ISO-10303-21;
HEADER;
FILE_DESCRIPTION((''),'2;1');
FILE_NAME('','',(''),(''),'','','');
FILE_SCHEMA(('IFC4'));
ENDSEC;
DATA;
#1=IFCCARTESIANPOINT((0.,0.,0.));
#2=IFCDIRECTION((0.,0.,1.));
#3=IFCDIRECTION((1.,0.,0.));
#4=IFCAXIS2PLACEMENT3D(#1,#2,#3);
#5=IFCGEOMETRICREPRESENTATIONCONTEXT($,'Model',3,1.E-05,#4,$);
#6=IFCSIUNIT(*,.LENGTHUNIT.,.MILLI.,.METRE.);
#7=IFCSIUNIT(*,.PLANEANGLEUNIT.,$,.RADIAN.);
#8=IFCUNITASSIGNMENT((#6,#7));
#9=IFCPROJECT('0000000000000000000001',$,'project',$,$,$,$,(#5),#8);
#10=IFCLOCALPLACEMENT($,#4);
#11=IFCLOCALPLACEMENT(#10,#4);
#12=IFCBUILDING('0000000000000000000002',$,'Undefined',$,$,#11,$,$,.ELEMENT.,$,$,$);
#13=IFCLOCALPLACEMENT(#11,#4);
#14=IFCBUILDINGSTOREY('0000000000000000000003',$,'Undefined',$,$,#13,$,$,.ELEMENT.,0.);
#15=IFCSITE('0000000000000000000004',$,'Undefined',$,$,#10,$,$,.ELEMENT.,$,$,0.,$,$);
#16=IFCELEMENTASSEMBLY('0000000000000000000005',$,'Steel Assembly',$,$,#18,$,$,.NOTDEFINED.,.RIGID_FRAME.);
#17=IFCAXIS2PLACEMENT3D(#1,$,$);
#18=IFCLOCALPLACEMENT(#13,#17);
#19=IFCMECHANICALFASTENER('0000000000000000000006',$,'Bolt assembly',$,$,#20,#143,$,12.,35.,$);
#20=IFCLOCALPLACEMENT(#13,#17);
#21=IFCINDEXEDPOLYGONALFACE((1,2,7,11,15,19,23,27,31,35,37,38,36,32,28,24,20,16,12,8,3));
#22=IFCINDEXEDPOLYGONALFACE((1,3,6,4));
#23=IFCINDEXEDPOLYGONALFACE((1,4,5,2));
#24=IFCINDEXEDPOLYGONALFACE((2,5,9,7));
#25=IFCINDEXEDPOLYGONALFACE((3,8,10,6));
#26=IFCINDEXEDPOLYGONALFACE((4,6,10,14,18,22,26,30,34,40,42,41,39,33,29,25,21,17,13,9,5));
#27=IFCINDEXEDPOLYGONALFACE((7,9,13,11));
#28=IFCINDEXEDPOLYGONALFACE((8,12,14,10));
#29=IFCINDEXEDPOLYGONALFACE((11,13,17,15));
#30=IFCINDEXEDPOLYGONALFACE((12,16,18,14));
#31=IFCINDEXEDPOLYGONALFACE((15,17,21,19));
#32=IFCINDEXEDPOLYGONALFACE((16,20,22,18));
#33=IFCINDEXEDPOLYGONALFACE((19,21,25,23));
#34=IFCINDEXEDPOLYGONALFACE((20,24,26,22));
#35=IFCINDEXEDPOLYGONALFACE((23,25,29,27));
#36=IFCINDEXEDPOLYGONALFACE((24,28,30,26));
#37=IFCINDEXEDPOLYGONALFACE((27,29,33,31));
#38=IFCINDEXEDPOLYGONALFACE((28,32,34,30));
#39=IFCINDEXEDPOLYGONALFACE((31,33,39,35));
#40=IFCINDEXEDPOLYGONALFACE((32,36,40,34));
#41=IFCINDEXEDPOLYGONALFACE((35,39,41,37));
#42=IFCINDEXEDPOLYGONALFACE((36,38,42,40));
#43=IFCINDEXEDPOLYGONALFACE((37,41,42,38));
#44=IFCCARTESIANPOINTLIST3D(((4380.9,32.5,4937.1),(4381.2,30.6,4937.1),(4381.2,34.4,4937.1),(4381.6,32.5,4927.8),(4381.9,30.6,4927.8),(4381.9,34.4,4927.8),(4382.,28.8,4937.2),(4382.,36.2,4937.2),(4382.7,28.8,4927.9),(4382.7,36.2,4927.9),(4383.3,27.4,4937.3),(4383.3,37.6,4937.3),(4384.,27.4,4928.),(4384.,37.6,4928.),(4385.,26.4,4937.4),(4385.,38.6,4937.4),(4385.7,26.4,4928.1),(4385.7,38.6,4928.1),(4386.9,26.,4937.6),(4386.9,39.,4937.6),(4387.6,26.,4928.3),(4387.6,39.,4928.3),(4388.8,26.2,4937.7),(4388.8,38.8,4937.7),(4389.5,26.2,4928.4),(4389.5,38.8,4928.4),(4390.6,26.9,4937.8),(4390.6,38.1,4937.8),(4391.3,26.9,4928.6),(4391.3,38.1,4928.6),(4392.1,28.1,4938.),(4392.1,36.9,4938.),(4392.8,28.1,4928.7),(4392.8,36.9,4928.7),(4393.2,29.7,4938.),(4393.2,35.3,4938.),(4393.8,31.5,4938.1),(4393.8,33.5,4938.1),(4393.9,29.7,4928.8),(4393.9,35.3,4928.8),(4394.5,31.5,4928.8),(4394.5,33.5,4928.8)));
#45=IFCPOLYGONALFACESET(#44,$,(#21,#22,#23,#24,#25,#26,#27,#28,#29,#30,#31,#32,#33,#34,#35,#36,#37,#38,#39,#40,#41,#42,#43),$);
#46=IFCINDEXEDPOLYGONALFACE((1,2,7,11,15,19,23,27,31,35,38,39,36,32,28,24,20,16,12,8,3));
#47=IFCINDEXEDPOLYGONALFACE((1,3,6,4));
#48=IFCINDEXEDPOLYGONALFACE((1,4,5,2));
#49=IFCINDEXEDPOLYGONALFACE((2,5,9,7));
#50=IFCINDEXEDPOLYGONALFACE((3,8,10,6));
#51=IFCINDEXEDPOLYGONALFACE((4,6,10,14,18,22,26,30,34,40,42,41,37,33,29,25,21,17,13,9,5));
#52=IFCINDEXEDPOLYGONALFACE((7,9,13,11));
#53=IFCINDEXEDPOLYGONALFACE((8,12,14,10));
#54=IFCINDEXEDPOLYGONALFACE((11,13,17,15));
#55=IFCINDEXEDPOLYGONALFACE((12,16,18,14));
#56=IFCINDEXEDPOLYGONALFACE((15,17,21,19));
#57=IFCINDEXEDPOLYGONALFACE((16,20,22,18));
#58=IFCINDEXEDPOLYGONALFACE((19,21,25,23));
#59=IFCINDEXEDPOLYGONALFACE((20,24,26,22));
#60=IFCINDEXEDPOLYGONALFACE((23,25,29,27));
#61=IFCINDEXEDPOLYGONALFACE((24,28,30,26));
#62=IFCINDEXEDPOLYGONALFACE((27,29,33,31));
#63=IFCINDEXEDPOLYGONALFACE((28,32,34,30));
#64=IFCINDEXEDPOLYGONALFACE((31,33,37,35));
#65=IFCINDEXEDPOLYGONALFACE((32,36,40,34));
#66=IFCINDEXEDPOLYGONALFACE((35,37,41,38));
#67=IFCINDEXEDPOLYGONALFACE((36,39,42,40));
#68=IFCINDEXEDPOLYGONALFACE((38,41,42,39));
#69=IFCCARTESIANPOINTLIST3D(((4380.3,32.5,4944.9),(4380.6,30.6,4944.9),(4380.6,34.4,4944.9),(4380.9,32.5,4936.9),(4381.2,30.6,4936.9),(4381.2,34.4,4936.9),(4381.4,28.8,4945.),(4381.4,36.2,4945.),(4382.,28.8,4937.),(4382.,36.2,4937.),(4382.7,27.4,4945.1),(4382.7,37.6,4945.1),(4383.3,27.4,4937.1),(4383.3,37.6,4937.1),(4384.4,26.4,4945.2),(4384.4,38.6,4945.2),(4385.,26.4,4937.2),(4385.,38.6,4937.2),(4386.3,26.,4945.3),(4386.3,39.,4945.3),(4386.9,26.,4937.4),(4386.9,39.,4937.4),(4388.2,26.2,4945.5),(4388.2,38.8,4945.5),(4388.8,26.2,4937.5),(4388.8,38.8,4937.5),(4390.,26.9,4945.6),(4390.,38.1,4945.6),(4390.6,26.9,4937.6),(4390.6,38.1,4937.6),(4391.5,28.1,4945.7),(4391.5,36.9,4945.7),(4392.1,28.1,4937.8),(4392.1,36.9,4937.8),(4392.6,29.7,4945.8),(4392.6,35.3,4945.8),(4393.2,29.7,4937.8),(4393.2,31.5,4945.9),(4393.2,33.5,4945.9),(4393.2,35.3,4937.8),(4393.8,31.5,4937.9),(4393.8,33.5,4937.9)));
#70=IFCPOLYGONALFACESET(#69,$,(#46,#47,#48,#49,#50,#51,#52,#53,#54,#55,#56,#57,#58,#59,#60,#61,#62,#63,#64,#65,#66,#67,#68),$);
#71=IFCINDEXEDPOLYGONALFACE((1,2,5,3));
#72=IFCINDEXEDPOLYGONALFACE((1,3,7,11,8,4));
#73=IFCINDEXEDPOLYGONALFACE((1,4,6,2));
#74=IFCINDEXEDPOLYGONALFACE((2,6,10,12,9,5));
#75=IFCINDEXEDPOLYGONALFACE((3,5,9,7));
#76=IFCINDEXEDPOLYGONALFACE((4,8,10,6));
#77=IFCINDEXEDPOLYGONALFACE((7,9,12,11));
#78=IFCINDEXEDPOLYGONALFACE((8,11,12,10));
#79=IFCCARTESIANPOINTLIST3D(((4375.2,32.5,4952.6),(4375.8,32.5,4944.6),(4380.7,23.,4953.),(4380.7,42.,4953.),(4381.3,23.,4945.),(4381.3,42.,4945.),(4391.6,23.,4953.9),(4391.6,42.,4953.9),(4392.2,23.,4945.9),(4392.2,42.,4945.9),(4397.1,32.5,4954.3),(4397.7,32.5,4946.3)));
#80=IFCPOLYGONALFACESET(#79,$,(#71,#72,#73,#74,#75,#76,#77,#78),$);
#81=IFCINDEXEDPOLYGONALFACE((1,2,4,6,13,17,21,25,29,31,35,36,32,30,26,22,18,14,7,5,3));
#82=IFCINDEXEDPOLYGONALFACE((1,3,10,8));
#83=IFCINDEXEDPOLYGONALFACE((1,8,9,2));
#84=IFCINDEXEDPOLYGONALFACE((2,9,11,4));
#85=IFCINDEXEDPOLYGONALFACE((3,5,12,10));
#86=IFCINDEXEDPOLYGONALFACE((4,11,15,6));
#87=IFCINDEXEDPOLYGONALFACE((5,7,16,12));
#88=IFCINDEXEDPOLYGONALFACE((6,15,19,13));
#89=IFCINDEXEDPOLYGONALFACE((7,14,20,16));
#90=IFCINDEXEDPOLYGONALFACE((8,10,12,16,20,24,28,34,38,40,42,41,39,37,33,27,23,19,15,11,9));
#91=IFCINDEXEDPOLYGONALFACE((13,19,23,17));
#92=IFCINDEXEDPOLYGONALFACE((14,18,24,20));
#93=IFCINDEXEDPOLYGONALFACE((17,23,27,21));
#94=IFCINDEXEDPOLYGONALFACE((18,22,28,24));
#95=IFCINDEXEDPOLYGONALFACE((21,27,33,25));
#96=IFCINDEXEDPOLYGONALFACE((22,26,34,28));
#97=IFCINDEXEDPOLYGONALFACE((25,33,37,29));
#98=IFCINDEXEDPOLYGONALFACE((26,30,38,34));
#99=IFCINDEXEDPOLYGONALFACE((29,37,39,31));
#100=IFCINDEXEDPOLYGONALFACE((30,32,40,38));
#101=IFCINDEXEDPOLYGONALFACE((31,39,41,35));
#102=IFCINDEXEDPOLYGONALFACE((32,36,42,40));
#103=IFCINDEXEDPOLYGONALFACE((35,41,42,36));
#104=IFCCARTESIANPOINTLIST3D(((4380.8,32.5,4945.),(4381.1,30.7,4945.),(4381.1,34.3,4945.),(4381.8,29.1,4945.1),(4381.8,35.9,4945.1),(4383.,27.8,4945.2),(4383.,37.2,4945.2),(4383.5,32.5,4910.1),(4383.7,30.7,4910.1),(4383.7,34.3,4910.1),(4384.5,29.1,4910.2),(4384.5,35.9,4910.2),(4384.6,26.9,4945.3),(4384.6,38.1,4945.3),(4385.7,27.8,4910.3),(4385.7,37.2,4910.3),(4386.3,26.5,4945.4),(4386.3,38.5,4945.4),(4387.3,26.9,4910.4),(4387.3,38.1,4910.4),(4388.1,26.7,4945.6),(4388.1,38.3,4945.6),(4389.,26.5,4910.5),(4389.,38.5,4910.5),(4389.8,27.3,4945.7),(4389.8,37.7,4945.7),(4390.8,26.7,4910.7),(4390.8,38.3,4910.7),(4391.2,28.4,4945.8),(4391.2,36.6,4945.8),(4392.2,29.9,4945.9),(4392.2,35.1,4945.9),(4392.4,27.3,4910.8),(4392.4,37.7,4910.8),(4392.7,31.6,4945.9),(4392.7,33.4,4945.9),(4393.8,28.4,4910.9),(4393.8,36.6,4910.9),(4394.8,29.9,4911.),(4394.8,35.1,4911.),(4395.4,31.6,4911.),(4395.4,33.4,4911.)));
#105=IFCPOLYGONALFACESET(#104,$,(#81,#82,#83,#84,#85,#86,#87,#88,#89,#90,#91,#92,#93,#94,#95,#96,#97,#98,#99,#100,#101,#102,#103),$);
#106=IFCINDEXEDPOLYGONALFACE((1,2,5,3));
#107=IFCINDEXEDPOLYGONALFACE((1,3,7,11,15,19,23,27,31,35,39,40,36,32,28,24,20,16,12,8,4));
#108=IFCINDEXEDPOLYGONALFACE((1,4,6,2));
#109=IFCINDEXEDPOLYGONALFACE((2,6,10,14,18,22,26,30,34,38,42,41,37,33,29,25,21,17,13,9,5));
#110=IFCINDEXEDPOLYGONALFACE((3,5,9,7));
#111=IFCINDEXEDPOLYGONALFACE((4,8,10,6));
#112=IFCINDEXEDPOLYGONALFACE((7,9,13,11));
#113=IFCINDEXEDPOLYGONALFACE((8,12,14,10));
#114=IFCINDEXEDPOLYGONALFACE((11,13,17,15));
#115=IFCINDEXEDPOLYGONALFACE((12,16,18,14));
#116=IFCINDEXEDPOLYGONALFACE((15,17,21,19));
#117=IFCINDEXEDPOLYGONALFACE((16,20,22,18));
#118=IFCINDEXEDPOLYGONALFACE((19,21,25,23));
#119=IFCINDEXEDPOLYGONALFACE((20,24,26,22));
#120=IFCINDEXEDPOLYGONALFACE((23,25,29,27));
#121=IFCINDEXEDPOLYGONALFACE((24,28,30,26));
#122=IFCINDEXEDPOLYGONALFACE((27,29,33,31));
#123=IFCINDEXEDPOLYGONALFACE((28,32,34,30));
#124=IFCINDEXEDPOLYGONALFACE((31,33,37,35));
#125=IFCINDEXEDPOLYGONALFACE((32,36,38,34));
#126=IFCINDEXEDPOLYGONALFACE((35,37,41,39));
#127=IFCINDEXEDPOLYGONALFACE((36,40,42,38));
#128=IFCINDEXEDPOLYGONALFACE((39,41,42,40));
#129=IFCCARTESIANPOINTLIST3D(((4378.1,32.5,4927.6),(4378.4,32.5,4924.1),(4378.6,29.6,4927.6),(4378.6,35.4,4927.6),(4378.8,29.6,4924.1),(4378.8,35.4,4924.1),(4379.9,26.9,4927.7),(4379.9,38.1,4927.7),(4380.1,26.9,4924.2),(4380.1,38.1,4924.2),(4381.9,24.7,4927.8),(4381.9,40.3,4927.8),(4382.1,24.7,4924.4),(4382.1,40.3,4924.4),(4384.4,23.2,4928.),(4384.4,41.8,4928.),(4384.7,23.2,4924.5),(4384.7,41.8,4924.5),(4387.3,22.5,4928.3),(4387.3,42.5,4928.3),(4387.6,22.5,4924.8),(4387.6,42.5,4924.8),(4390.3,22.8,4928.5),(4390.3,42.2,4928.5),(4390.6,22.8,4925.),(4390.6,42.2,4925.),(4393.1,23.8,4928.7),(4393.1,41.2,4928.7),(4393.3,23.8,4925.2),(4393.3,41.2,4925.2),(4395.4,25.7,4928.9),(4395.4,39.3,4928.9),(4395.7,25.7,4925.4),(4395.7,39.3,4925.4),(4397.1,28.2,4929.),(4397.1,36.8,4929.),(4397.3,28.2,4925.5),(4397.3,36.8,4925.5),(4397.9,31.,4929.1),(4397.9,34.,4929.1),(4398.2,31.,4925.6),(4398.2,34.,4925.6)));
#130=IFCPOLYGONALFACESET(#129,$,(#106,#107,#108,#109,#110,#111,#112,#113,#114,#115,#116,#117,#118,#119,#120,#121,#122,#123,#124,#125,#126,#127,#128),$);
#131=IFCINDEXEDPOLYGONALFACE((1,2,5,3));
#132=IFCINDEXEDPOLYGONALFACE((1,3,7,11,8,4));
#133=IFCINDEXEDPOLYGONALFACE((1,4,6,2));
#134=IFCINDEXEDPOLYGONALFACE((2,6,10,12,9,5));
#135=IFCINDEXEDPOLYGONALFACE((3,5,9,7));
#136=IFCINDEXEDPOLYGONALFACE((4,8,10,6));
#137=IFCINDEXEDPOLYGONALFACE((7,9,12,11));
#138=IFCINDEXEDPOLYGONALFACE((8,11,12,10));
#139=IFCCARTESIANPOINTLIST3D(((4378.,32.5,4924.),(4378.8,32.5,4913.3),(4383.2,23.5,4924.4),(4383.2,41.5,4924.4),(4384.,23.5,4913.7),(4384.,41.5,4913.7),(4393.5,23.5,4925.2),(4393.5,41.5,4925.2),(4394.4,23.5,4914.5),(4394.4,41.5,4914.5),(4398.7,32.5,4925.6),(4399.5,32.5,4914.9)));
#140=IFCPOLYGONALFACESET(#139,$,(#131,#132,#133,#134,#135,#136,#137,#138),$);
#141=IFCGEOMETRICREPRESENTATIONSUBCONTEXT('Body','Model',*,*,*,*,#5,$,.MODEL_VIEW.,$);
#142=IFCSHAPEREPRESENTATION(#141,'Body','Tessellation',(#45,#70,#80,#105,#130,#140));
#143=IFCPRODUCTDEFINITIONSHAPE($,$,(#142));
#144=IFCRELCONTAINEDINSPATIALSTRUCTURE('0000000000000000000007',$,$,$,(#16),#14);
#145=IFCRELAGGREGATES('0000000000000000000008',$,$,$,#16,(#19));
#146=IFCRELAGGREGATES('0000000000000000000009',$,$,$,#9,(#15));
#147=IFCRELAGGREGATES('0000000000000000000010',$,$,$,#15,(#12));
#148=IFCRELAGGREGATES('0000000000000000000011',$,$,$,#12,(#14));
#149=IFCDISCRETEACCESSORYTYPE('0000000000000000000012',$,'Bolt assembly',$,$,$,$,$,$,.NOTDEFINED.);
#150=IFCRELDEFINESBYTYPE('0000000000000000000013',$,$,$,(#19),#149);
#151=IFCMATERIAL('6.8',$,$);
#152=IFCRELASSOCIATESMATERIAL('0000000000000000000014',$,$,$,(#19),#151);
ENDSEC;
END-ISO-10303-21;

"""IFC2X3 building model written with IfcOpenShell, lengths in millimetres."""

from ifc_helpers import new_model, si_unit, frame, origin_with_axes, origin_2d_with_axis, place, context, subcontext, project, spatial, polyline, circle, outline, extrude, source, transform, mapped, material, type_object, element, aggregate, save


model = new_model("IFC2X3")

# Units and contexts
model_context = context("Model", 3, precision=1e-05, world=origin_with_axes())
body_context = subcontext(model_context, "Body", "Model", "MODEL_VIEW")
ifc_project = project(units=[si_unit("LENGTHUNIT", "METRE", prefix="MILLI"), si_unit("PLANEANGLEUNIT", "RADIAN")], contexts=[model_context])

# Site, building, storey
site_placement = place(None, origin_with_axes())
site = spatial("IfcSite", under=ifc_project, at=site_placement, Name="Undefined", CompositionType="ELEMENT", RefElevation=0.0)
building_placement = place(site_placement, origin_with_axes())
building = spatial("IfcBuilding", under=site, at=building_placement, Name="Undefined", CompositionType="ELEMENT")
storey_placement = place(building_placement, origin_with_axes())
storey = spatial("IfcBuildingStorey", under=building, at=storey_placement, Name="Undefined", CompositionType="ELEMENT", Elevation=0.0)

# Element assembly, mechanical fastener
assembly_1_placement = place(storey_placement, origin_with_axes())
assembly_1 = element("IfcElementAssembly", 1, at=assembly_1_placement, inside=storey, Name="Steel Assembly", AssemblyPlace="NOTDEFINED", PredefinedType="RIGID_FRAME")
ifc_material_1 = material(Name="6.8")
discrete_accessory_type_1 = type_object("IfcDiscreteAccessoryType", Name="Bolt assembly")
shared_shape_1 = source(origin_with_axes(), body_context, "Body", "SweptSolid", [
    extrude(circle(Radius=6.5, at=origin_2d_with_axis()), frame((0.0, -0.1, 0.0), z_axis=(0.0, 1.0, 0.0), x_axis=(1.0, 0.0, 0.0)), (0.0, 0.0, 1.0), 9.3),
    extrude(circle(Radius=6.5, at=origin_2d_with_axis()), frame((0.0, -7.9, 0.0), z_axis=(0.0, 1.0, 0.0), x_axis=(1.0, 0.0, 0.0)), (0.0, 0.0, 1.0), 8.0),
    extrude(outline(polyline([(11.0, 0.0), (5.5, 9.5), (-5.5, 9.5), (-11.0, 0.0), (-5.5, -9.5), (5.5, -9.5), (11.0, 0.0)])), frame((0.0, -16.0, 0.0), z_axis=(0.0, 1.0, 0.0), x_axis=(1.0, 0.0, 0.0)), (0.0, 0.0, 1.0), 8.0),
    extrude(circle(Radius=6.0, at=origin_2d_with_axis()), frame((0.0, -8.0, 0.0), z_axis=(0.0, 1.0, 0.0), x_axis=(1.0, 0.0, 0.0)), (0.0, 0.0, 1.0), 35.0),
    extrude(circle(Radius=10.0, at=origin_2d_with_axis()), frame((0.0, 9.2, 0.0), z_axis=(0.0, 1.0, 0.0), x_axis=(1.0, 0.0, 0.0)), (0.0, 0.0, 1.0), 3.5),
    extrude(outline(polyline([(10.4, 0.0), (5.2, 9.0), (-5.2, 9.0), (-10.4, 0.0), (-5.2, -9.0), (5.2, -9.0), (10.4, 0.0)])), frame((0.0, 12.7, 0.0), z_axis=(0.0, 1.0, 0.0), x_axis=(1.0, 0.0, 0.0)), (0.0, 0.0, 1.0), 10.8),
])
mechanical_fastener_1_placement = place(assembly_1_placement, frame((4387.4, 32.5, 4937.5), z_axis=(0.0, -1.0, 0.0), x_axis=(-0.997054, 0.0, -0.076696)))
mechanical_fastener_1 = element("IfcMechanicalFastener", 2, at=mechanical_fastener_1_placement, type_object=discrete_accessory_type_1, material=ifc_material_1, Name="Bolt assembly", NominalDiameter=12.0, NominalLength=35.0, context=body_context, shape_type="MappedRepresentation", body=[
    mapped(shared_shape_1, transform((0.0, 0.0, 0.0))),
])
aggregate(assembly_1, [mechanical_fastener_1])

save(model, "model.ifc")
